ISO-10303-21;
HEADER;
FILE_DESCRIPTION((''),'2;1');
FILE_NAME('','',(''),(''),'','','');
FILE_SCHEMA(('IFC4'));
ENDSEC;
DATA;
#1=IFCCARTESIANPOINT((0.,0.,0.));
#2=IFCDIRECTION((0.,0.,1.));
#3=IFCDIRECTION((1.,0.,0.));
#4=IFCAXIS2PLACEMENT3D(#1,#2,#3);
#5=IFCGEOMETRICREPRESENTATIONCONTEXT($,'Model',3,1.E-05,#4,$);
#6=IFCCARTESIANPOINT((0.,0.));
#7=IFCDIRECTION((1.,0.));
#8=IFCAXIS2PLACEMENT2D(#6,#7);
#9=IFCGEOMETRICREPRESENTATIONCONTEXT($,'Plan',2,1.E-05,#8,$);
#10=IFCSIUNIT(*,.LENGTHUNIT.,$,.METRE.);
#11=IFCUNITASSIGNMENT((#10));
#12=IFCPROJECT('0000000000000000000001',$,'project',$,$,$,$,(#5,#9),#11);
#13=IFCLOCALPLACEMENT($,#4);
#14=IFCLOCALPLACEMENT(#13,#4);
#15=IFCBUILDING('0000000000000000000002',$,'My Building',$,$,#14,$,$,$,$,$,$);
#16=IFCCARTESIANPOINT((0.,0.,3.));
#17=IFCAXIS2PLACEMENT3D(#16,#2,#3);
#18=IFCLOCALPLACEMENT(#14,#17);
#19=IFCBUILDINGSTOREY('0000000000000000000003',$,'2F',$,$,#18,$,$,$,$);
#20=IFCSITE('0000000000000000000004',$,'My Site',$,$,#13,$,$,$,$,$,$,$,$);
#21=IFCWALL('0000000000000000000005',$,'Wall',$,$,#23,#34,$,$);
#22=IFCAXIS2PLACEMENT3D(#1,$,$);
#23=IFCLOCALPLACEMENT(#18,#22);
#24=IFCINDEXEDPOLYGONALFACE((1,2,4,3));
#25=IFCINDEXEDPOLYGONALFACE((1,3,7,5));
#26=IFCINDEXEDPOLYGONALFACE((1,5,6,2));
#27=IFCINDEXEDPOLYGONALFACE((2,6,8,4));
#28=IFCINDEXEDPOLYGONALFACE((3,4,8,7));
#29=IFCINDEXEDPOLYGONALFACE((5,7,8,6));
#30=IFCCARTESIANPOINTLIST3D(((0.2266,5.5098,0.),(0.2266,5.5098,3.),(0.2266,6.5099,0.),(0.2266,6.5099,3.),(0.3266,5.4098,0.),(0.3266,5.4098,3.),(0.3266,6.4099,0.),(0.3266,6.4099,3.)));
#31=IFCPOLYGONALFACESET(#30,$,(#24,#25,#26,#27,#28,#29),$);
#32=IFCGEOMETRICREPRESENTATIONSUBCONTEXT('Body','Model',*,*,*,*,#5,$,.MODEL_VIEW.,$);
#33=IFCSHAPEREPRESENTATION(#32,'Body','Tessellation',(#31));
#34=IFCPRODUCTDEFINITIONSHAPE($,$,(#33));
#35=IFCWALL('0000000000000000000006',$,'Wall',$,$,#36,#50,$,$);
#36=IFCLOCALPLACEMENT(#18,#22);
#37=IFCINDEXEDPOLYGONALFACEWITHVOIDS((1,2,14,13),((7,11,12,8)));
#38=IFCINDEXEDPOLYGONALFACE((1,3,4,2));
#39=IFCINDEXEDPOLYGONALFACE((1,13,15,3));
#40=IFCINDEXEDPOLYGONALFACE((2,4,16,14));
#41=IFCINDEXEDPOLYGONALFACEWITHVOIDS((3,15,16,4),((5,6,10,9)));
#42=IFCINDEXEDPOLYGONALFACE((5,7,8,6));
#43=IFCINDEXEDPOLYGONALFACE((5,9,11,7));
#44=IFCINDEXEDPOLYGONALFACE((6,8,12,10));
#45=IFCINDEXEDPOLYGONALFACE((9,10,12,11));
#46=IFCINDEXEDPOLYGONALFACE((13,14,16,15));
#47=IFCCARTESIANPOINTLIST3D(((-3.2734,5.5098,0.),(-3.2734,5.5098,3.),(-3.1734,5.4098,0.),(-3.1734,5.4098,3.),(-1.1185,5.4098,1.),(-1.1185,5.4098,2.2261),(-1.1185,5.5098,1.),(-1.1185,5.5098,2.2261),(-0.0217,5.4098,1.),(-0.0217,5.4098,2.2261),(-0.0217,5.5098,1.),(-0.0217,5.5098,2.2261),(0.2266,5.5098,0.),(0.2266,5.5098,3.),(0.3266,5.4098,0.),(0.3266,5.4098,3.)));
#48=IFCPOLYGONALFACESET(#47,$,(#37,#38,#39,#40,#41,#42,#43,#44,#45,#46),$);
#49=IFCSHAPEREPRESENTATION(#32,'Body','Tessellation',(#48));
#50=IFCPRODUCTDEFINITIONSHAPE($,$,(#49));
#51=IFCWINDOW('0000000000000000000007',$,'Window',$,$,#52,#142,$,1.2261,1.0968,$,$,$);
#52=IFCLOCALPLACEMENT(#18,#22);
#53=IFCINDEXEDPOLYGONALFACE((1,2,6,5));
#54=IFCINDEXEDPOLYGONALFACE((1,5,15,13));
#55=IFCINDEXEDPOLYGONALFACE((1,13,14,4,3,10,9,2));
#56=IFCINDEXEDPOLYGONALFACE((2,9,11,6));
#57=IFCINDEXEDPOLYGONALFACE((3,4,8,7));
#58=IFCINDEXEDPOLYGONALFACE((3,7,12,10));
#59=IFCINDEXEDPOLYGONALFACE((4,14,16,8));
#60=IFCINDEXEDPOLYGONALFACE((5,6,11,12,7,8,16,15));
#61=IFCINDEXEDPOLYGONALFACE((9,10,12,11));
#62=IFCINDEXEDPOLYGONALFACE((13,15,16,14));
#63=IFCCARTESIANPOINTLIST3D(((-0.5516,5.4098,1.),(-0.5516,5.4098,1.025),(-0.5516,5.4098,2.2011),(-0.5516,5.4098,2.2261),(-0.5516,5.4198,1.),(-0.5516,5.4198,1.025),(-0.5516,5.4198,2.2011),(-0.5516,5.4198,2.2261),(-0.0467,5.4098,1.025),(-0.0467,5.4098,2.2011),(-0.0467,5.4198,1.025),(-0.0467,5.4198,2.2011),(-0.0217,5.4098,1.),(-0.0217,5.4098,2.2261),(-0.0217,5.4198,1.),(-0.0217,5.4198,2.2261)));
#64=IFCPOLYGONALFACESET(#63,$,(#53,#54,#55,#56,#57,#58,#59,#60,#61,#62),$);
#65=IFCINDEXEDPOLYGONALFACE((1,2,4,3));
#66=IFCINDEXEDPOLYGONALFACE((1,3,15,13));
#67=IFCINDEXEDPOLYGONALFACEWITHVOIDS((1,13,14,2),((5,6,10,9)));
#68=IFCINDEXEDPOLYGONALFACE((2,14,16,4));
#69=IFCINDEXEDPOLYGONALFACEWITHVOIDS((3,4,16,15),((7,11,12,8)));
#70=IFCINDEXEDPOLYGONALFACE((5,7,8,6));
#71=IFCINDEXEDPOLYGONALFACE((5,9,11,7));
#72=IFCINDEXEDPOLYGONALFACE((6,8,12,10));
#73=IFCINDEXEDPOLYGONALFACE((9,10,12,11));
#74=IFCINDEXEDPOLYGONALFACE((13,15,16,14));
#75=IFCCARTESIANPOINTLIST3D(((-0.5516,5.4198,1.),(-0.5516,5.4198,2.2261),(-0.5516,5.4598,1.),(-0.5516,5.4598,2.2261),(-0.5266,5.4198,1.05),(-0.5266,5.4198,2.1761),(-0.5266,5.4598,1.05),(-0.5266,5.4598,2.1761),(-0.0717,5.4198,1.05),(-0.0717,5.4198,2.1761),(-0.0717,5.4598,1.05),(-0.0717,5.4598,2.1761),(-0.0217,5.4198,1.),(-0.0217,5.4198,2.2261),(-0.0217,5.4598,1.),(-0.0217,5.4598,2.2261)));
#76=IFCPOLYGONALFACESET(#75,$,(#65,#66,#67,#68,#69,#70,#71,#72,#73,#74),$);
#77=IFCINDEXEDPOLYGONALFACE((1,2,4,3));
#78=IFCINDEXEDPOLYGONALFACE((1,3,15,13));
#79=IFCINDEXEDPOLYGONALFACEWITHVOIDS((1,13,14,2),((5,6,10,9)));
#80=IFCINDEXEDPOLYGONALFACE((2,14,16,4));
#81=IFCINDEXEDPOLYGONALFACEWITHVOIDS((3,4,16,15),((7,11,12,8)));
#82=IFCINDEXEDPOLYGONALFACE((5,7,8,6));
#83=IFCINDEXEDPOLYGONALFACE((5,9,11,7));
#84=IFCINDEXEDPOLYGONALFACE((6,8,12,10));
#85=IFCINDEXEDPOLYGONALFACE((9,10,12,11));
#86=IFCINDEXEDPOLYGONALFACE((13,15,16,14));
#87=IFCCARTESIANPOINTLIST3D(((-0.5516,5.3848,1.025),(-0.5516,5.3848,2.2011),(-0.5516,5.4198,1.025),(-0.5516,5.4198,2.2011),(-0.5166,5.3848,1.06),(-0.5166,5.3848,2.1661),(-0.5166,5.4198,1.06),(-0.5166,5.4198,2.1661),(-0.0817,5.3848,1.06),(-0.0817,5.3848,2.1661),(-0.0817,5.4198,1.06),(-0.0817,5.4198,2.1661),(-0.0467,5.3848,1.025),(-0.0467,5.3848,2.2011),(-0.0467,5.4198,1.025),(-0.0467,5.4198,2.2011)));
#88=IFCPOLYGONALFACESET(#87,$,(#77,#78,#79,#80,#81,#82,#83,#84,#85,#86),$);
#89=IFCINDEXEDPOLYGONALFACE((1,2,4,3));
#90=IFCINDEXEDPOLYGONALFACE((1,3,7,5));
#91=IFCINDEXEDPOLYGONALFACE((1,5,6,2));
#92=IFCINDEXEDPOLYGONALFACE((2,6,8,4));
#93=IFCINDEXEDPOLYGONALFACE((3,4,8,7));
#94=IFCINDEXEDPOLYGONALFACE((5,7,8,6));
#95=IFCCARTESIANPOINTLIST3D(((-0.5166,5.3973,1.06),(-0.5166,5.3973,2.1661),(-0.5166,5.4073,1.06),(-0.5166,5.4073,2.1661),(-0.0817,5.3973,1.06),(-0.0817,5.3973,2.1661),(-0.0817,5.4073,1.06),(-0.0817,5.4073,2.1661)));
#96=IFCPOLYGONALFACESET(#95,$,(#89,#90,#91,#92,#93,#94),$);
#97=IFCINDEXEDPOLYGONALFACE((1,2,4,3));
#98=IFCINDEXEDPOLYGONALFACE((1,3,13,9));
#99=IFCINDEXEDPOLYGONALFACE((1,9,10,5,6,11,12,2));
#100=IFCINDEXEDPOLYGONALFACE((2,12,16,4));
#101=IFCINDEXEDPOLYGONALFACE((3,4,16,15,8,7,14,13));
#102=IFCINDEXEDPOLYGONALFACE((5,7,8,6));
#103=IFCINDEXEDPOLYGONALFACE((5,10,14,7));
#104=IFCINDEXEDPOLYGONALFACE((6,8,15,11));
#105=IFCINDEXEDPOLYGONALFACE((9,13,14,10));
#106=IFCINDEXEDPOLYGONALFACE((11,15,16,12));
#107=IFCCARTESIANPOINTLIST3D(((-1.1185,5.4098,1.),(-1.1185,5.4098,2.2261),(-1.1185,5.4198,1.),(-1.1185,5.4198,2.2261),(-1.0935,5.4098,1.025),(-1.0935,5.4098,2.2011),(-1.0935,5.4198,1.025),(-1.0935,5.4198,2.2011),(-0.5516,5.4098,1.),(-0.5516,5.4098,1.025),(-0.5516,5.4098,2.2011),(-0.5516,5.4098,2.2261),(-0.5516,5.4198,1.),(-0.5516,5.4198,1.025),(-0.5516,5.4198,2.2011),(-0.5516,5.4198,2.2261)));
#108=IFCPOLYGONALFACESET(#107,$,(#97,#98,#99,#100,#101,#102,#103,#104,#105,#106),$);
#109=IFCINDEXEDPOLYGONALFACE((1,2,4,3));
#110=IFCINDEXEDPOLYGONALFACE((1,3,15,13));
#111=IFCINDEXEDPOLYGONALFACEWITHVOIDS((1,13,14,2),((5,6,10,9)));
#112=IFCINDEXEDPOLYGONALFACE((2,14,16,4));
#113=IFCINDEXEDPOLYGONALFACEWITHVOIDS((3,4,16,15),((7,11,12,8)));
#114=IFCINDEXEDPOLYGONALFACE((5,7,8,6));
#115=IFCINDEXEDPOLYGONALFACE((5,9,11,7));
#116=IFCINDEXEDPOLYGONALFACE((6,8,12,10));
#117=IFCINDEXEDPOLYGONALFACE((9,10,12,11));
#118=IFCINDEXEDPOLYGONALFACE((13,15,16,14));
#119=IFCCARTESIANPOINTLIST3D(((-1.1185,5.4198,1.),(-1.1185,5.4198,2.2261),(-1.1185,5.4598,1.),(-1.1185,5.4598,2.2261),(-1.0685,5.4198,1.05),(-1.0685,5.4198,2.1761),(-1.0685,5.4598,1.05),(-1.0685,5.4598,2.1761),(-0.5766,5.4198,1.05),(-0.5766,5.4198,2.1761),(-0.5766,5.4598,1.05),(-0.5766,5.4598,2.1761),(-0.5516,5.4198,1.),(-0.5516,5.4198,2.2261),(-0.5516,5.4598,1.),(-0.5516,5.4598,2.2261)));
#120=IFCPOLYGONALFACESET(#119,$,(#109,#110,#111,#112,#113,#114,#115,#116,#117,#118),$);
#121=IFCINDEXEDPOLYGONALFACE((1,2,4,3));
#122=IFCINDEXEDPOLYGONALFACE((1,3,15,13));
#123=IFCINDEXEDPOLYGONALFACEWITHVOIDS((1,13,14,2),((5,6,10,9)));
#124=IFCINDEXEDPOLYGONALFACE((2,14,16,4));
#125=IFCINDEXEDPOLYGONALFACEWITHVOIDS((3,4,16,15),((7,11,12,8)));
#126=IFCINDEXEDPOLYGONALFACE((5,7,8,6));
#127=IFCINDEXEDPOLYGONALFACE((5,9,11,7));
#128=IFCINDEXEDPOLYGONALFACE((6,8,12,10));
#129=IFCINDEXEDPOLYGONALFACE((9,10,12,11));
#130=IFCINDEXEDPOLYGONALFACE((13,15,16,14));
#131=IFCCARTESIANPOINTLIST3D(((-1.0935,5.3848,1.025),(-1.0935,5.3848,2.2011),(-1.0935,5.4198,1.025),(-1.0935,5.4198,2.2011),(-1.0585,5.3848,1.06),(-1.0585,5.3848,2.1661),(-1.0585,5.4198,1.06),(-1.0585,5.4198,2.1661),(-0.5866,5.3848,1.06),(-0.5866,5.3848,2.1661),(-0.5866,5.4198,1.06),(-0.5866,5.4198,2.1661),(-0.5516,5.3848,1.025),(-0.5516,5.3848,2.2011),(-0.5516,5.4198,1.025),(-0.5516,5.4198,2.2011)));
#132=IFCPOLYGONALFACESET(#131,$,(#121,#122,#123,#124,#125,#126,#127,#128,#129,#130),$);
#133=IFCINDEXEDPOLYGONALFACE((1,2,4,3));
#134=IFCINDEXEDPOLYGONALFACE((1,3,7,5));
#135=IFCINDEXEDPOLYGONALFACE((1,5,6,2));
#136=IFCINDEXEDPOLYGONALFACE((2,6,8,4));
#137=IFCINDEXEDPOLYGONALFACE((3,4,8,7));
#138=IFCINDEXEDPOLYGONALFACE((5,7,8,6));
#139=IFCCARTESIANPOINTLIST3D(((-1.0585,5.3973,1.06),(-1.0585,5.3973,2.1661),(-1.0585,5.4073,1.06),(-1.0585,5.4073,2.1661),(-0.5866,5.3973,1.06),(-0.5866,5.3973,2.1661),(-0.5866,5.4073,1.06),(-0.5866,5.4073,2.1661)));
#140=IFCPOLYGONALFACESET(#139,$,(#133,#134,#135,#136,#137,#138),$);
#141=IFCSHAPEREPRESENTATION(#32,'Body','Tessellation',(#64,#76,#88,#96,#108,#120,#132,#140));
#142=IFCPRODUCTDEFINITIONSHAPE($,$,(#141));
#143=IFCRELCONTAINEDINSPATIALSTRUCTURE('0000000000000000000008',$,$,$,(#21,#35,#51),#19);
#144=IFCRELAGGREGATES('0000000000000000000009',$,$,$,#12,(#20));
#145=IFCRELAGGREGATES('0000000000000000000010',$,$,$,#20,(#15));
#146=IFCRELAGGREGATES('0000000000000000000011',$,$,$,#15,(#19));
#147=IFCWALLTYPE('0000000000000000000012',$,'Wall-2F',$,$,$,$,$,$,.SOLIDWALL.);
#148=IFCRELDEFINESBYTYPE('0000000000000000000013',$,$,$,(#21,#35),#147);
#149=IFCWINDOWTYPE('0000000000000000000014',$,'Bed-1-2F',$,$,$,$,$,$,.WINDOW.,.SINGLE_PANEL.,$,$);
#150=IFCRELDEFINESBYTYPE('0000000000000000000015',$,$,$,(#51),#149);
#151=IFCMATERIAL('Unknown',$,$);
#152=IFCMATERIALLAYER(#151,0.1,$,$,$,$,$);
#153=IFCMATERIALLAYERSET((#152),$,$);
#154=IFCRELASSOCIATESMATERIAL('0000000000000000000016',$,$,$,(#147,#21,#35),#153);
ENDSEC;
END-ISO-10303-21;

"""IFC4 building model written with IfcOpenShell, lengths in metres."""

from ifc_helpers import new_model, entity, si_unit, frame, origin_with_axes, origin_2d_with_axis, place, context, subcontext, project, spatial, line, indexed_curve, outline, extrude, shape, source, transform, mapped, material, layer, layer_set, layer_usage, type_object, type_shapes, element, fill, save


model = new_model("IFC4")

# Units and contexts
model_context = context("Model", 3, precision=1e-05, world=origin_with_axes())
plan_context = context("Plan", 2, precision=1e-05, world=origin_2d_with_axis())
body_context_1 = subcontext(model_context, "Body", "Model", "MODEL_VIEW")
body_context_2 = subcontext(plan_context, "Body", "Plan", "PLAN_VIEW")
ifc_project = project(units=[si_unit("LENGTHUNIT", "METRE")], contexts=[model_context, plan_context])

# Site, building, storey
site_placement = place(None, origin_with_axes())
site = spatial("IfcSite", under=ifc_project, at=site_placement, Name="My Site")
building_placement = place(site_placement, origin_with_axes())
building = spatial("IfcBuilding", under=site, at=building_placement, Name="My Building")
storey_placement = place(building_placement, frame((0.0, 0.0, 3.0), z_axis=(0.0, 0.0, 1.0), x_axis=(1.0, 0.0, 0.0)))
storey = spatial("IfcBuildingStorey", under=building, at=storey_placement, Name="2F")

# Shared definitions
ifc_material = material(Name="Unknown")

# Shared definitions
ifc_layer_1 = layer(ifc_material, 0.1)
ifc_layer_set_1 = layer_set([ifc_layer_1])
wall_type = type_object("IfcWallType", Name="Wall-2F", PredefinedType="SOLIDWALL", material=ifc_layer_set_1)

# Wall
ifc_layer_usage_1 = layer_usage(ifc_layer_set_1, "AXIS2", "POSITIVE", 0.0)
wall_1_placement = place(storey_placement, frame((0.2266, 6.5099, 0.0), z_axis=(0.0, 0.0, 1.0), x_axis=(0.0, -1.0, 0.0)))
element("IfcWall", 1, at=wall_1_placement, inside=storey, type_object=wall_type, material=ifc_layer_usage_1, Name="Wall", context=body_context_1, shape_type="SweptSolid", body=[
    extrude(outline(indexed_curve([(0.0, 0.0), (0.1, 0.1), (1.1001, 0.1), (1.0001, 0.0)], segments=[line(1, 2, 3, 4, 1)])), origin_with_axes(), (0.0, 0.0, 1.0), 3.0),
])

# Wall, opening, window
ifc_layer_usage_2 = layer_usage(ifc_layer_set_1, "AXIS2", "POSITIVE", 0.0)
wall_2_placement = place(storey_placement, frame((0.2266, 5.5098, 0.0), z_axis=(0.0, 0.0, 1.0), x_axis=(-1.0, 0.0, 0.0)))
wall_2 = element("IfcWall", 2, at=wall_2_placement, inside=storey, type_object=wall_type, material=ifc_layer_usage_2, Name="Wall", context=body_context_1, shape_type="SweptSolid", body=[
    extrude(outline(indexed_curve([(0.0, 0.0), (-0.1, 0.1), (3.3999, 0.1), (3.4999, 0.0)], segments=[line(1, 2, 3, 4, 1)])), origin_with_axes(), (0.0, 0.0, 1.0), 3.0),
])
shared_shape_1 = source(origin_with_axes(), body_context_1, "Body", "SweptSolid", [
    extrude(outline(indexed_curve([(0.0, 0.0), (1.0968, 0.0), (1.0968, 1.2261), (0.0, 1.2261)], segments=[line(1, 2, 3, 4, 1)])), frame((0.0, -0.6, 0.0), z_axis=(0.0, -1.0, 0.0), x_axis=(1.0, 0.0, 0.0)), (0.0, 0.0, -1.0), 1.2),
])
opening_1_placement = place(wall_2_placement, frame((0.2483, 0.0, 1.0), z_axis=(0.0, 0.0, 1.0), x_axis=(1.0, 0.0, 0.0)))
opening_1 = element("IfcOpeningElement", 3, at=opening_1_placement, cuts=wall_2, PredefinedType="OPENING", context=body_context_1, shape_type="MappedRepresentation", body=[
    mapped(shared_shape_1, transform((0.0, 0.0, 0.0), x_axis=(1.0, 0.0, 0.0), y_axis=(0.0, 1.0, 0.0), z_axis=(0.0, 0.0, 1.0), scale=1.0)),
])
window_type_1 = type_object("IfcWindowType", Name="Bed-1-2F", PartitioningType="SINGLE_PANEL", PredefinedType="WINDOW")
shared_shape_2 = source(origin_with_axes(), body_context_1, "Body", "SweptSolid", [
    extrude(outline(indexed_curve([(0.5299, 0.0), (0.0, 0.0), (0.0, 1.2261), (0.5299, 1.2261), (0.5299, 1.2011), (0.025, 1.2011), (0.025, 0.025), (0.5299, 0.025)], segments=[line(1, 2, 3, 4, 5, 6, 7, 8, 1)])), frame((0.0, 0.09, 0.0), z_axis=(0.0, -1.0, 0.0), x_axis=(1.0, 0.0, 0.0)), (0.0, 0.0, -1.0), 0.01),
    extrude(outline(indexed_curve([(0.0, 0.0), (0.5299, 0.0), (0.5299, 1.2261), (0.0, 1.2261)], segments=[line(1, 2, 3, 4, 1)]), holes=[indexed_curve([(0.05, 0.05), (0.5049, 0.05), (0.5049, 1.1761), (0.05, 1.1761)], segments=[line(1, 2, 3, 4, 1)])]), frame((0.0, 0.05, 0.0), z_axis=(0.0, -1.0, 0.0), x_axis=(1.0, 0.0, 0.0)), (0.0, 0.0, -1.0), 0.04),
    extrude(outline(indexed_curve([(0.0, 0.0), (0.5049, 0.0), (0.5049, 1.1761), (0.0, 1.1761)], segments=[line(1, 2, 3, 4, 1)]), holes=[indexed_curve([(0.035, 0.035), (0.4699, 0.035), (0.4699, 1.1411), (0.035, 1.1411)], segments=[line(1, 2, 3, 4, 1)])]), frame((0.025, 0.09, 0.025), z_axis=(0.0, -1.0, 0.0), x_axis=(1.0, 0.0, 0.0)), (0.0, 0.0, -1.0), 0.035),
    extrude(outline(indexed_curve([(0.035, 0.035), (0.4699, 0.035), (0.4699, 1.1411), (0.035, 1.1411)], segments=[line(1, 2, 3, 4, 1)])), frame((0.025, 0.1025, 0.025), z_axis=(0.0, -1.0, 0.0), x_axis=(1.0, 0.0, 0.0)), (0.0, 0.0, -1.0), 0.01),
    extrude(outline(indexed_curve([(0.0, 1.2261), (0.5669, 1.2261), (0.5669, 0.0), (0.0, 0.0), (0.0, 0.025), (0.5419, 0.025), (0.5419, 1.2011), (0.0, 1.2011)], segments=[line(1, 2, 3, 4, 5, 6, 7, 8, 1)])), frame((0.5299, 0.09, 0.0), z_axis=(0.0, -1.0, 0.0), x_axis=(1.0, 0.0, 0.0)), (0.0, 0.0, -1.0), 0.01),
    extrude(outline(indexed_curve([(0.0, 0.0), (0.5669, 0.0), (0.5669, 1.2261), (0.0, 1.2261)], segments=[line(1, 2, 3, 4, 1)]), holes=[indexed_curve([(0.025, 0.05), (0.5169, 0.05), (0.5169, 1.1761), (0.025, 1.1761)], segments=[line(1, 2, 3, 4, 1)])]), frame((0.5299, 0.05, 0.0), z_axis=(0.0, -1.0, 0.0), x_axis=(1.0, 0.0, 0.0)), (0.0, 0.0, -1.0), 0.04),
    extrude(outline(indexed_curve([(0.0, 0.0), (0.5419, 0.0), (0.5419, 1.1761), (0.0, 1.1761)], segments=[line(1, 2, 3, 4, 1)]), holes=[indexed_curve([(0.035, 0.035), (0.5069, 0.035), (0.5069, 1.1411), (0.035, 1.1411)], segments=[line(1, 2, 3, 4, 1)])]), frame((0.5299, 0.09, 0.025), z_axis=(0.0, -1.0, 0.0), x_axis=(1.0, 0.0, 0.0)), (0.0, 0.0, -1.0), 0.035),
    extrude(outline(indexed_curve([(0.035, 0.035), (0.5069, 0.035), (0.5069, 1.1411), (0.035, 1.1411)], segments=[line(1, 2, 3, 4, 1)])), frame((0.5299, 0.1025, 0.025), z_axis=(0.0, -1.0, 0.0), x_axis=(1.0, 0.0, 0.0)), (0.0, 0.0, -1.0), 0.01),
])
shared_shape_3 = source(origin_with_axes(), body_context_2, "Body", "Curve2D", [
    entity("IfcIndexedPolyCurve", entity("IfcCartesianPointList2D", [[0.05, 0.05], [0.5049, 0.05]])),
    entity("IfcIndexedPolyCurve", entity("IfcCartesianPointList2D", [[0.0, 0.1], [0.025, 0.1], [0.025, 0.09], [0.05, 0.09], [0.05, 0.05], [0.0, 0.05]]), [entity("IfcLineIndex", [1, 2, 3, 4, 5, 6, 1])]),
    entity("IfcIndexedPolyCurve", entity("IfcCartesianPointList2D", [[0.5299, 0.1], [0.5299, 0.1], [0.5299, 0.09], [0.5049, 0.09], [0.5049, 0.05], [0.5299, 0.05]])),
    entity("IfcIndexedPolyCurve", entity("IfcCartesianPointList2D", [[0.025, 0.09], [0.06, 0.09], [0.06, 0.125], [0.025, 0.125]]), [entity("IfcLineIndex", [1, 2, 3, 4, 1])]),
    entity("IfcIndexedPolyCurve", entity("IfcCartesianPointList2D", [[0.5299, 0.09], [0.4949, 0.09], [0.4949, 0.125], [0.5299, 0.125]]), [entity("IfcLineIndex", [1, 2, 3, 4, 1])]),
    entity("IfcIndexedPolyCurve", entity("IfcCartesianPointList2D", [[0.06, 0.09], [0.4949, 0.09]])),
    entity("IfcIndexedPolyCurve", entity("IfcCartesianPointList2D", [[0.06, 0.125], [0.4949, 0.125]])),
    entity("IfcIndexedPolyCurve", entity("IfcCartesianPointList2D", [[0.06, 0.1075], [0.4949, 0.1075]])),
    entity("IfcIndexedPolyCurve", entity("IfcCartesianPointList2D", [[0.5549, 0.05], [1.0468, 0.05]])),
    entity("IfcIndexedPolyCurve", entity("IfcCartesianPointList2D", [[0.5299, 0.1], [0.5299, 0.1], [0.5299, 0.09], [0.5549, 0.09], [0.5549, 0.05], [0.5299, 0.05]])),
    entity("IfcIndexedPolyCurve", entity("IfcCartesianPointList2D", [[1.0968, 0.1], [1.0718, 0.1], [1.0718, 0.09], [1.0468, 0.09], [1.0468, 0.05], [1.0968, 0.05]]), [entity("IfcLineIndex", [1, 2, 3, 4, 5, 6, 1])]),
    entity("IfcIndexedPolyCurve", entity("IfcCartesianPointList2D", [[0.5299, 0.09], [0.5649, 0.09], [0.5649, 0.125], [0.5299, 0.125]]), [entity("IfcLineIndex", [1, 2, 3, 4, 1])]),
    entity("IfcIndexedPolyCurve", entity("IfcCartesianPointList2D", [[1.0718, 0.09], [1.0368, 0.09], [1.0368, 0.125], [1.0718, 0.125]]), [entity("IfcLineIndex", [1, 2, 3, 4, 1])]),
    entity("IfcIndexedPolyCurve", entity("IfcCartesianPointList2D", [[0.5649, 0.09], [1.0368, 0.09]])),
    entity("IfcIndexedPolyCurve", entity("IfcCartesianPointList2D", [[0.5649, 0.125], [1.0368, 0.125]])),
    entity("IfcIndexedPolyCurve", entity("IfcCartesianPointList2D", [[0.5649, 0.1075], [1.0368, 0.1075]])),
])
type_shapes(window_type_1, [shared_shape_2, shared_shape_3])
window_1_placement = place(opening_1_placement, origin_with_axes())
window_1 = element("IfcWindow", 4, at=window_1_placement, inside=storey, type_object=window_type_1, Name="Window", OverallHeight=1.2261, OverallWidth=1.0968, shapes=[
    shape(body_context_1, "Body", "MappedRepresentation", [mapped(shared_shape_2, transform((0.0, 0.0, 0.0), x_axis=(1.0, 0.0, 0.0), y_axis=(0.0, 1.0, 0.0), z_axis=(0.0, 0.0, 1.0), scale=1.0))]),
    shape(body_context_2, "Body", "MappedRepresentation", [mapped(shared_shape_3, transform((0.0, 0.0, 0.0), x_axis=(1.0, 0.0, 0.0), y_axis=(0.0, 1.0, 0.0), z_axis=(0.0, 0.0, 1.0), scale=1.0))]),
])
fill(opening_1, window_1)

save(model, "model.ifc")
